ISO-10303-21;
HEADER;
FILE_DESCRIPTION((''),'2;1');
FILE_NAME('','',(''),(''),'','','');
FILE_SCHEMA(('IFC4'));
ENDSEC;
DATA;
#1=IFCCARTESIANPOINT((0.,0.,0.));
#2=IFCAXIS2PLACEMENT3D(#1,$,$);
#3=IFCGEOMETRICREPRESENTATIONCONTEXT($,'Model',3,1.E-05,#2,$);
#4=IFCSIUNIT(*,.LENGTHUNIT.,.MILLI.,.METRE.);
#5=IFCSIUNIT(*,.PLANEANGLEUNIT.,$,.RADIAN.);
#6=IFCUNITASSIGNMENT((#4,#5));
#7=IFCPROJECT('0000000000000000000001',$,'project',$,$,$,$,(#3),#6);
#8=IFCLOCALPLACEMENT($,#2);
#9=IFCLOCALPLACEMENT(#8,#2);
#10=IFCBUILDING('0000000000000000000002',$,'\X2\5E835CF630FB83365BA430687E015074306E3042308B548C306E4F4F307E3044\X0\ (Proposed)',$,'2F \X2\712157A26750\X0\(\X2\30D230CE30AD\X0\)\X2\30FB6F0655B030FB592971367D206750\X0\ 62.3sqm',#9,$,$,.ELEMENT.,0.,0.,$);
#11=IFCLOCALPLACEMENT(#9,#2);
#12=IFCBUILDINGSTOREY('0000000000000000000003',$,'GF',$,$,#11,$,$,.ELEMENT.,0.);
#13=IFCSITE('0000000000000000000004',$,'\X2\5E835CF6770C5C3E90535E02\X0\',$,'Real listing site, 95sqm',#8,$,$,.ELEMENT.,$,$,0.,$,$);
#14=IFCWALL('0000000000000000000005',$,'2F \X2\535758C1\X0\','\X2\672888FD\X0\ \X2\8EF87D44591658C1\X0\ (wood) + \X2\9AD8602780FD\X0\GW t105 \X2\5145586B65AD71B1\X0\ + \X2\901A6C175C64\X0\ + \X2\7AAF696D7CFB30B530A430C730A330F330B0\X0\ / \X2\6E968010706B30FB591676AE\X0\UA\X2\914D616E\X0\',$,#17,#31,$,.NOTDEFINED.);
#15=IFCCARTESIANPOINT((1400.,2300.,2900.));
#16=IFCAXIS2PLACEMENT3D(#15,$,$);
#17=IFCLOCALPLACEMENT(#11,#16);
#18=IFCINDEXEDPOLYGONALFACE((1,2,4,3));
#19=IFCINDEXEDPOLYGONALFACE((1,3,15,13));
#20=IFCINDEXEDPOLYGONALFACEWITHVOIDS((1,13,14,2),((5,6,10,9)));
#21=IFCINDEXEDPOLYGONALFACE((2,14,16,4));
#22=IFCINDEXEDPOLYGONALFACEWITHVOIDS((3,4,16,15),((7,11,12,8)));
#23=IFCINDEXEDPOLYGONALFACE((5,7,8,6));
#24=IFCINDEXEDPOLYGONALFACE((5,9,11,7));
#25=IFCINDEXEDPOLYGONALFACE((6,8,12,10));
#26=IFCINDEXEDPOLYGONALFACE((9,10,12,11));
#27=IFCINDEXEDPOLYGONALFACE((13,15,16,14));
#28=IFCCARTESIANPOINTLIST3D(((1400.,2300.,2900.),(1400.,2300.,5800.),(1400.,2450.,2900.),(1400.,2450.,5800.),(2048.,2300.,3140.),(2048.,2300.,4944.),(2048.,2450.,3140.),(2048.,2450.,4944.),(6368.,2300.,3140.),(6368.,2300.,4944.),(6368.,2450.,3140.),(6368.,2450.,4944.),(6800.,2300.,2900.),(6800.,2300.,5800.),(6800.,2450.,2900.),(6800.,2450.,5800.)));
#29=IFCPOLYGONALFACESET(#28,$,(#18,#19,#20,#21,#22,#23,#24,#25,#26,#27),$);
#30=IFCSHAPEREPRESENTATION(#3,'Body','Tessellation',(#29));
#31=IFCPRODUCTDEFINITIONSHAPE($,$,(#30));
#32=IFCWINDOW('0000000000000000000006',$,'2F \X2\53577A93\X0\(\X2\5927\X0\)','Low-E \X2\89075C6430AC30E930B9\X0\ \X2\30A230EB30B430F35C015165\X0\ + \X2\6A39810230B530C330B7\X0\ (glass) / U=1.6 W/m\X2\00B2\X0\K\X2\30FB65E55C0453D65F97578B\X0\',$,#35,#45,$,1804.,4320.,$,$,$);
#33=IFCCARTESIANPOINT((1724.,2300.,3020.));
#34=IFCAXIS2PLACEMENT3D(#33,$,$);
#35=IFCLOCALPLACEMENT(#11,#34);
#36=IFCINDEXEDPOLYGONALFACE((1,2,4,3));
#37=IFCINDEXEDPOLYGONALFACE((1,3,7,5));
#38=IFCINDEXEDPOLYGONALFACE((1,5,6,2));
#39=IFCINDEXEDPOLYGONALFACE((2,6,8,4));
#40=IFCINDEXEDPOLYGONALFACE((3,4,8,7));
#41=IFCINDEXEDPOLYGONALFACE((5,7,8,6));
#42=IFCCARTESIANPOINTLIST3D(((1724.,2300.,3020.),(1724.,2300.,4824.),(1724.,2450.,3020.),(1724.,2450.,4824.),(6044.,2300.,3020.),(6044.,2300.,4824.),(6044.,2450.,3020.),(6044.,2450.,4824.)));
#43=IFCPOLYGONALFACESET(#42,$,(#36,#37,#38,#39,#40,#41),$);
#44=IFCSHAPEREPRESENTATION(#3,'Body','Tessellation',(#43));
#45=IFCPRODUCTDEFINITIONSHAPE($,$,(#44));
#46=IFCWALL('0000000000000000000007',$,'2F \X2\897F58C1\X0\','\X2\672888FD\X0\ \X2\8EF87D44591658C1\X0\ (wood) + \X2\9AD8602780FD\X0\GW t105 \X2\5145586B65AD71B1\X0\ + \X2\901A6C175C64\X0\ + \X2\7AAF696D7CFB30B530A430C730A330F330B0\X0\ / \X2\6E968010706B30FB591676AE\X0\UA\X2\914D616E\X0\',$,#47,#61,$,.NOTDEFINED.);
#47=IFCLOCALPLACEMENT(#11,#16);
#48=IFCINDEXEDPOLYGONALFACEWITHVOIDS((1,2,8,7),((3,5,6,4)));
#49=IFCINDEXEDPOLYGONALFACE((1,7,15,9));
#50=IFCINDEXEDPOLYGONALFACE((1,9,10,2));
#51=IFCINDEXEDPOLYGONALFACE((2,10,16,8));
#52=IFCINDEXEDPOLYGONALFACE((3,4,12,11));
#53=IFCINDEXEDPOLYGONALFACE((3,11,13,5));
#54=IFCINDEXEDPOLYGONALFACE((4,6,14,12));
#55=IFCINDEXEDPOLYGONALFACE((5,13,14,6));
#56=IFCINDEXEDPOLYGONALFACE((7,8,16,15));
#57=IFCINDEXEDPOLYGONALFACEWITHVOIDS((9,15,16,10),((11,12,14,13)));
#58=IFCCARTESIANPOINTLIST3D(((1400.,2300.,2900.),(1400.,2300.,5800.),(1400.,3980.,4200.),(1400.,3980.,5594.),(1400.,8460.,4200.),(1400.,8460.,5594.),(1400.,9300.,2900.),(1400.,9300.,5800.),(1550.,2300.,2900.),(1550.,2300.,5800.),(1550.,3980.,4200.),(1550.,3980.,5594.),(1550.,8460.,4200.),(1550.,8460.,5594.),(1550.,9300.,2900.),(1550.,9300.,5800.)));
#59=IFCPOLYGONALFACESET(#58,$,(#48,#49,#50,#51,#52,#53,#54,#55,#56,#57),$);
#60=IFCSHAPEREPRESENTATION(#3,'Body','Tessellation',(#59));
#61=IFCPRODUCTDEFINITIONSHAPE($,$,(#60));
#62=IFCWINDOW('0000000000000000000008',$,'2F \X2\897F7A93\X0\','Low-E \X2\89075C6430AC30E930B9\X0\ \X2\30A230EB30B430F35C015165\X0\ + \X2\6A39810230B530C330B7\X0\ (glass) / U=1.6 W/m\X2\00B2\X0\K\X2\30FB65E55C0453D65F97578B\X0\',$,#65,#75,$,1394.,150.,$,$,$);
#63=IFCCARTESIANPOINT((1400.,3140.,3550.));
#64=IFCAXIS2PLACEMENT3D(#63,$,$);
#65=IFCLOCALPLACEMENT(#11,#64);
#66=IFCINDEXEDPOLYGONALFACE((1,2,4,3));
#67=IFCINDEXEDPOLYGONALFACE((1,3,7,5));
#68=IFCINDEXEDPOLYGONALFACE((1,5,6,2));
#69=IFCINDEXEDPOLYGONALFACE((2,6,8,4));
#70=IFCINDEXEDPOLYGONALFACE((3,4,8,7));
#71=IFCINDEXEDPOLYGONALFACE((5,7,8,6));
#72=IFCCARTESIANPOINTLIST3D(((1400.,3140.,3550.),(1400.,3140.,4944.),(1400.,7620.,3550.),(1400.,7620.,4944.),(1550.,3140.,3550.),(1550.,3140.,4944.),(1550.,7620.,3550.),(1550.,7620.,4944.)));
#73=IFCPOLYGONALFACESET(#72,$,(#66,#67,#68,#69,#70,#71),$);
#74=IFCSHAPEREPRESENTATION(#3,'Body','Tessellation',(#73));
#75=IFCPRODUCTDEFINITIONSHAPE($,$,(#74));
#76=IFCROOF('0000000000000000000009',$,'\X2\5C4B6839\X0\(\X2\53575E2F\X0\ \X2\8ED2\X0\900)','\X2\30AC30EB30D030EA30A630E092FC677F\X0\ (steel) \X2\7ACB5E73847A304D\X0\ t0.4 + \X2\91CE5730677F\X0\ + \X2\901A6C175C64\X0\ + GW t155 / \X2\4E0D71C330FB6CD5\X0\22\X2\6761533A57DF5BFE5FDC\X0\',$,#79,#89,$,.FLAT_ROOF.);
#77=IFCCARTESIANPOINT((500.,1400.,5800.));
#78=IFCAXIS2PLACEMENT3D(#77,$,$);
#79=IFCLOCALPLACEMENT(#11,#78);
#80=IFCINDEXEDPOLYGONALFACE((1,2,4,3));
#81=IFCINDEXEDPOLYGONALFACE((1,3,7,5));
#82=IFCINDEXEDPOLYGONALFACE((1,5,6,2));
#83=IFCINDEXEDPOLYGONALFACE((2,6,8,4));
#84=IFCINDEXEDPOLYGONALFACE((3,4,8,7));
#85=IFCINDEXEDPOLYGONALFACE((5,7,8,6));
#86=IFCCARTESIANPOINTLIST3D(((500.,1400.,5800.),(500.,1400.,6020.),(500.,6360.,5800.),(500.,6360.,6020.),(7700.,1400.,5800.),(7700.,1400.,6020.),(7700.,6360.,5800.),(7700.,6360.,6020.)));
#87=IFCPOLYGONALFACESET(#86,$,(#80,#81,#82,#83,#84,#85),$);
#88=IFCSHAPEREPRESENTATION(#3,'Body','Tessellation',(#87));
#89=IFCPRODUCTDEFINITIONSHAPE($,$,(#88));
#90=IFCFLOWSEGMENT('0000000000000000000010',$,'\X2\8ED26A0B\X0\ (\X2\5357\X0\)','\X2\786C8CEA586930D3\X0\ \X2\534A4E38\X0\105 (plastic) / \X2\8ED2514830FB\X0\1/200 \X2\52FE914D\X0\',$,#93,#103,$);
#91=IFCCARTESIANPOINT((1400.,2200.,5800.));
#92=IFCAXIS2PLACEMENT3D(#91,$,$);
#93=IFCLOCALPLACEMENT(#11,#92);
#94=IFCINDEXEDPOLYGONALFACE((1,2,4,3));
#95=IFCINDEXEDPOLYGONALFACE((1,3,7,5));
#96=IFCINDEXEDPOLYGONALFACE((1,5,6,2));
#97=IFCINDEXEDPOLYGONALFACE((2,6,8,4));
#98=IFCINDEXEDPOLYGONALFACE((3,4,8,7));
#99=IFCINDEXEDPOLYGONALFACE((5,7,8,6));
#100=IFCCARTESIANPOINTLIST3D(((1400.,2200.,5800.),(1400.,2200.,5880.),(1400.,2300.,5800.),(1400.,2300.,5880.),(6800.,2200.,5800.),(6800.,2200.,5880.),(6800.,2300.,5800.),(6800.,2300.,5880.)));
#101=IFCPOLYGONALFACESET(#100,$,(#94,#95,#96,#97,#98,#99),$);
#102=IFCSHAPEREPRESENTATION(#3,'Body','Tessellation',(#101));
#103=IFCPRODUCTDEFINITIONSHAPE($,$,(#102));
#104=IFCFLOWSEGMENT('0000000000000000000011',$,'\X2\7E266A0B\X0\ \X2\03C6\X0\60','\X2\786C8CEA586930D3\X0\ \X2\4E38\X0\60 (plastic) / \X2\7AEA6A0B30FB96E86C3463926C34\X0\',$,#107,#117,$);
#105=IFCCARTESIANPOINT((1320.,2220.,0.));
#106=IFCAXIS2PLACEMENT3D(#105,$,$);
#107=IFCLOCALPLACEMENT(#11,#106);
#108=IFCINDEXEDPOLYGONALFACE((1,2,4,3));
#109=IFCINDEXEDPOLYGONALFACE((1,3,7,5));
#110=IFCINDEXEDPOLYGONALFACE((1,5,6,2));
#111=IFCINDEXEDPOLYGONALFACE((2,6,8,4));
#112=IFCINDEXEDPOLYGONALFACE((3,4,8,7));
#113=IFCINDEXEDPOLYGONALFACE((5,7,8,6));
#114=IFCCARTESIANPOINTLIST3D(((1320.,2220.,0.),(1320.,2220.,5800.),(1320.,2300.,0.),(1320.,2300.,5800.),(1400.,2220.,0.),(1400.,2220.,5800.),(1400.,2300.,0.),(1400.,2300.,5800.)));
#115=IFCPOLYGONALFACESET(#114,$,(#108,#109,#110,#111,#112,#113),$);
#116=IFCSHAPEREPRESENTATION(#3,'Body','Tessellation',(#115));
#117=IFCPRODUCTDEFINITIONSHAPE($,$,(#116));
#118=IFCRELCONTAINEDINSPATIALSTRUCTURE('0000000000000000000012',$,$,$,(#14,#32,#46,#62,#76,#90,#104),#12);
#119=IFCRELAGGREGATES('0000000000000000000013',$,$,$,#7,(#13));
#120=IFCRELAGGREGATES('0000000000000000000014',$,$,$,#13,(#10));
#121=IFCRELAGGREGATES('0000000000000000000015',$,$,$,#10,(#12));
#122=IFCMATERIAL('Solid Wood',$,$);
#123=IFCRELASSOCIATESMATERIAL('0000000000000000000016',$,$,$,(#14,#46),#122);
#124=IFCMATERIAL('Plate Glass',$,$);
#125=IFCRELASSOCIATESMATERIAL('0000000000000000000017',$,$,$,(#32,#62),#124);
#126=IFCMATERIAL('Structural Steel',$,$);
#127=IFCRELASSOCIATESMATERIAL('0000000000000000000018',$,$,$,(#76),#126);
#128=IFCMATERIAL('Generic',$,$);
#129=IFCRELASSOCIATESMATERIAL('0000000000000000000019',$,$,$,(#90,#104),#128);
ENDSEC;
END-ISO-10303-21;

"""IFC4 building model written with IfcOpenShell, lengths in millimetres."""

from ifc_helpers import new_model, si_unit, frame, frame_2d, origin, place, context, project, spatial, rectangle, extrude, material, element, fill, save


model = new_model("IFC4")

# Units and contexts
model_context = context("Model", 3, precision=1e-05, world=origin())
ifc_project = project(units=[si_unit("LENGTHUNIT", "METRE", prefix="MILLI"), si_unit("PLANEANGLEUNIT", "RADIAN")], contexts=[model_context])

# Site, building, storey
site_placement = place(None, origin())
site = spatial("IfcSite", under=ifc_project, at=site_placement, Name="広島県尾道市", ObjectType="Real listing site, 95sqm", CompositionType="ELEMENT", RefElevation=0.0)
building_placement = place(site_placement, origin())
building = spatial("IfcBuilding", under=site, at=building_placement, Name="広島・茶室と縁側のある和の住まい (Proposed)", ObjectType="2F 無垢材(ヒノキ)・漆喰・天然素材 62.3sqm", CompositionType="ELEMENT", ElevationOfRefHeight=0.0, ElevationOfTerrain=0.0)
storey_placement = place(building_placement, origin())
storey = spatial("IfcBuildingStorey", under=building, at=storey_placement, Name="GF", CompositionType="ELEMENT", Elevation=0.0)

# Shared definitions
ifc_material_1 = material(Name="Solid Wood")

# Shared definitions
ifc_material_2 = material(Name="Plate Glass")

# Walls, openings, windows
wall_1_placement = place(storey_placement, frame((1400.0, 2300.0, 2900.0)))
wall_1 = element("IfcWall", 1, at=wall_1_placement, inside=storey, material=ifc_material_1, Name="2F 南壁", Description="木製 軸組外壁 (wood) + 高性能GW t105 充填断熱 + 通気層 + 窯業系サイディング / 準耐火・外皮UA配慮", PredefinedType="NOTDEFINED", context=model_context, shape_type="SweptSolid", body=[
    extrude(rectangle(XDim=5400.0, YDim=150.0, at=frame_2d((2700.0, 75.0))), frame((1400.0, 2300.0, 2900.0)), (0.0, 0.0, 1.0), 2900.0),
])
opening_1_placement = place(storey_placement, frame((1724.0, 2300.0, 3020.0)))
opening_1 = element("IfcOpeningElement", 2, at=opening_1_placement, cuts=wall_1, PredefinedType="NOTDEFINED", context=model_context, shape_type="SweptSolid", body=[
    extrude(rectangle(XDim=4320.0, YDim=150.0, at=frame_2d((2160.0, 75.0))), frame((1724.0, 2300.0, 3020.0)), (0.0, 0.0, 1.0), 1804.0),
])
window_1_placement = place(storey_placement, frame((1724.0, 2300.0, 3020.0)))
window_1 = element("IfcWindow", 3, at=window_1_placement, inside=storey, material=ifc_material_2, Name="2F 南窓(大)", Description="Low-E 複層ガラス アルゴン封入 + 樹脂サッシ (glass) / U=1.6 W/m²K・日射取得型", OverallHeight=1804.0, OverallWidth=4320.0, context=model_context, shape_type="SweptSolid", body=[
    extrude(rectangle(XDim=4320.0, YDim=150.0, at=frame_2d((2160.0, 75.0))), frame((1724.0, 2300.0, 3020.0)), (0.0, 0.0, 1.0), 1804.0),
])
fill(opening_1, window_1)
wall_2_placement = place(storey_placement, frame((1400.0, 2300.0, 2900.0)))
wall_2 = element("IfcWall", 4, at=wall_2_placement, inside=storey, material=ifc_material_1, Name="2F 西壁", Description="木製 軸組外壁 (wood) + 高性能GW t105 充填断熱 + 通気層 + 窯業系サイディング / 準耐火・外皮UA配慮", PredefinedType="NOTDEFINED", context=model_context, shape_type="SweptSolid", body=[
    extrude(rectangle(XDim=150.0, YDim=7000.0, at=frame_2d((75.0, 3500.0))), frame((1400.0, 2300.0, 2900.0)), (0.0, 0.0, 1.0), 2900.0),
])
opening_2_placement = place(storey_placement, frame((1400.0, 3140.0, 3550.0)))
opening_2 = element("IfcOpeningElement", 5, at=opening_2_placement, cuts=wall_2, PredefinedType="NOTDEFINED", context=model_context, shape_type="SweptSolid", body=[
    extrude(rectangle(XDim=150.0, YDim=4480.0, at=frame_2d((75.0, 2240.0))), frame((1400.0, 3140.0, 3550.0)), (0.0, 0.0, 1.0), 1394.0),
])
window_2_placement = place(storey_placement, frame((1400.0, 3140.0, 3550.0)))
window_2 = element("IfcWindow", 6, at=window_2_placement, inside=storey, material=ifc_material_2, Name="2F 西窓", Description="Low-E 複層ガラス アルゴン封入 + 樹脂サッシ (glass) / U=1.6 W/m²K・日射取得型", OverallHeight=1394.0, OverallWidth=150.0, context=model_context, shape_type="SweptSolid", body=[
    extrude(rectangle(XDim=150.0, YDim=4480.0, at=frame_2d((75.0, 2240.0))), frame((1400.0, 3140.0, 3550.0)), (0.0, 0.0, 1.0), 1394.0),
])
fill(opening_2, window_2)

# Roof
ifc_material_3 = material(Name="Structural Steel")
for number, where, name in (
    (7, (500.0, 1400.0, 5800.0), "屋根(南帯 軒900)"),
):
    element("IfcRoof", number, at=place(storey_placement, frame(where)), inside=storey, material=ifc_material_3, Name=name, Description="ガルバリウム鋼板 (steel) 立平葺き t0.4 + 野地板 + 通気層 + GW t155 / 不燃・法22条区域対応", PredefinedType="FLAT_ROOF", context=model_context, shape_type="SweptSolid", body=[
        extrude(rectangle(XDim=7200.0, YDim=4960.0, at=frame_2d((3600.0, 2480.0))), frame((500.0, 1400.0, 5800.0)), (0.0, 0.0, 1.0), 220.0),
    ])

# Flow segments
ifc_material_4 = material(Name="Generic")
flow_segment_1_placement = place(storey_placement, frame((1400.0, 2200.0, 5800.0)))
element("IfcFlowSegment", 8, at=flow_segment_1_placement, inside=storey, material=ifc_material_4, Name="軒樋 (南)", Description="硬質塩ビ 半丸105 (plastic) / 軒先・1/200 勾配", context=model_context, shape_type="SweptSolid", body=[
    extrude(rectangle(XDim=5400.0, YDim=100.0, at=frame_2d((2700.0, 50.0))), frame((1400.0, 2200.0, 5800.0)), (0.0, 0.0, 1.0), 80.0),
])
flow_segment_2_placement = place(storey_placement, frame((1320.0, 2220.0, 0.0)))
element("IfcFlowSegment", 9, at=flow_segment_2_placement, inside=storey, material=ifc_material_4, Name="縦樋 φ60", Description="硬質塩ビ 丸60 (plastic) / 竪樋・雨水排水", context=model_context, shape_type="SweptSolid", body=[
    extrude(rectangle(XDim=80.0, YDim=80.0, at=frame_2d((40.0, 40.0))), frame((1320.0, 2220.0, 0.0)), (0.0, 0.0, 1.0), 5800.0),
])

save(model, "model.ifc")
